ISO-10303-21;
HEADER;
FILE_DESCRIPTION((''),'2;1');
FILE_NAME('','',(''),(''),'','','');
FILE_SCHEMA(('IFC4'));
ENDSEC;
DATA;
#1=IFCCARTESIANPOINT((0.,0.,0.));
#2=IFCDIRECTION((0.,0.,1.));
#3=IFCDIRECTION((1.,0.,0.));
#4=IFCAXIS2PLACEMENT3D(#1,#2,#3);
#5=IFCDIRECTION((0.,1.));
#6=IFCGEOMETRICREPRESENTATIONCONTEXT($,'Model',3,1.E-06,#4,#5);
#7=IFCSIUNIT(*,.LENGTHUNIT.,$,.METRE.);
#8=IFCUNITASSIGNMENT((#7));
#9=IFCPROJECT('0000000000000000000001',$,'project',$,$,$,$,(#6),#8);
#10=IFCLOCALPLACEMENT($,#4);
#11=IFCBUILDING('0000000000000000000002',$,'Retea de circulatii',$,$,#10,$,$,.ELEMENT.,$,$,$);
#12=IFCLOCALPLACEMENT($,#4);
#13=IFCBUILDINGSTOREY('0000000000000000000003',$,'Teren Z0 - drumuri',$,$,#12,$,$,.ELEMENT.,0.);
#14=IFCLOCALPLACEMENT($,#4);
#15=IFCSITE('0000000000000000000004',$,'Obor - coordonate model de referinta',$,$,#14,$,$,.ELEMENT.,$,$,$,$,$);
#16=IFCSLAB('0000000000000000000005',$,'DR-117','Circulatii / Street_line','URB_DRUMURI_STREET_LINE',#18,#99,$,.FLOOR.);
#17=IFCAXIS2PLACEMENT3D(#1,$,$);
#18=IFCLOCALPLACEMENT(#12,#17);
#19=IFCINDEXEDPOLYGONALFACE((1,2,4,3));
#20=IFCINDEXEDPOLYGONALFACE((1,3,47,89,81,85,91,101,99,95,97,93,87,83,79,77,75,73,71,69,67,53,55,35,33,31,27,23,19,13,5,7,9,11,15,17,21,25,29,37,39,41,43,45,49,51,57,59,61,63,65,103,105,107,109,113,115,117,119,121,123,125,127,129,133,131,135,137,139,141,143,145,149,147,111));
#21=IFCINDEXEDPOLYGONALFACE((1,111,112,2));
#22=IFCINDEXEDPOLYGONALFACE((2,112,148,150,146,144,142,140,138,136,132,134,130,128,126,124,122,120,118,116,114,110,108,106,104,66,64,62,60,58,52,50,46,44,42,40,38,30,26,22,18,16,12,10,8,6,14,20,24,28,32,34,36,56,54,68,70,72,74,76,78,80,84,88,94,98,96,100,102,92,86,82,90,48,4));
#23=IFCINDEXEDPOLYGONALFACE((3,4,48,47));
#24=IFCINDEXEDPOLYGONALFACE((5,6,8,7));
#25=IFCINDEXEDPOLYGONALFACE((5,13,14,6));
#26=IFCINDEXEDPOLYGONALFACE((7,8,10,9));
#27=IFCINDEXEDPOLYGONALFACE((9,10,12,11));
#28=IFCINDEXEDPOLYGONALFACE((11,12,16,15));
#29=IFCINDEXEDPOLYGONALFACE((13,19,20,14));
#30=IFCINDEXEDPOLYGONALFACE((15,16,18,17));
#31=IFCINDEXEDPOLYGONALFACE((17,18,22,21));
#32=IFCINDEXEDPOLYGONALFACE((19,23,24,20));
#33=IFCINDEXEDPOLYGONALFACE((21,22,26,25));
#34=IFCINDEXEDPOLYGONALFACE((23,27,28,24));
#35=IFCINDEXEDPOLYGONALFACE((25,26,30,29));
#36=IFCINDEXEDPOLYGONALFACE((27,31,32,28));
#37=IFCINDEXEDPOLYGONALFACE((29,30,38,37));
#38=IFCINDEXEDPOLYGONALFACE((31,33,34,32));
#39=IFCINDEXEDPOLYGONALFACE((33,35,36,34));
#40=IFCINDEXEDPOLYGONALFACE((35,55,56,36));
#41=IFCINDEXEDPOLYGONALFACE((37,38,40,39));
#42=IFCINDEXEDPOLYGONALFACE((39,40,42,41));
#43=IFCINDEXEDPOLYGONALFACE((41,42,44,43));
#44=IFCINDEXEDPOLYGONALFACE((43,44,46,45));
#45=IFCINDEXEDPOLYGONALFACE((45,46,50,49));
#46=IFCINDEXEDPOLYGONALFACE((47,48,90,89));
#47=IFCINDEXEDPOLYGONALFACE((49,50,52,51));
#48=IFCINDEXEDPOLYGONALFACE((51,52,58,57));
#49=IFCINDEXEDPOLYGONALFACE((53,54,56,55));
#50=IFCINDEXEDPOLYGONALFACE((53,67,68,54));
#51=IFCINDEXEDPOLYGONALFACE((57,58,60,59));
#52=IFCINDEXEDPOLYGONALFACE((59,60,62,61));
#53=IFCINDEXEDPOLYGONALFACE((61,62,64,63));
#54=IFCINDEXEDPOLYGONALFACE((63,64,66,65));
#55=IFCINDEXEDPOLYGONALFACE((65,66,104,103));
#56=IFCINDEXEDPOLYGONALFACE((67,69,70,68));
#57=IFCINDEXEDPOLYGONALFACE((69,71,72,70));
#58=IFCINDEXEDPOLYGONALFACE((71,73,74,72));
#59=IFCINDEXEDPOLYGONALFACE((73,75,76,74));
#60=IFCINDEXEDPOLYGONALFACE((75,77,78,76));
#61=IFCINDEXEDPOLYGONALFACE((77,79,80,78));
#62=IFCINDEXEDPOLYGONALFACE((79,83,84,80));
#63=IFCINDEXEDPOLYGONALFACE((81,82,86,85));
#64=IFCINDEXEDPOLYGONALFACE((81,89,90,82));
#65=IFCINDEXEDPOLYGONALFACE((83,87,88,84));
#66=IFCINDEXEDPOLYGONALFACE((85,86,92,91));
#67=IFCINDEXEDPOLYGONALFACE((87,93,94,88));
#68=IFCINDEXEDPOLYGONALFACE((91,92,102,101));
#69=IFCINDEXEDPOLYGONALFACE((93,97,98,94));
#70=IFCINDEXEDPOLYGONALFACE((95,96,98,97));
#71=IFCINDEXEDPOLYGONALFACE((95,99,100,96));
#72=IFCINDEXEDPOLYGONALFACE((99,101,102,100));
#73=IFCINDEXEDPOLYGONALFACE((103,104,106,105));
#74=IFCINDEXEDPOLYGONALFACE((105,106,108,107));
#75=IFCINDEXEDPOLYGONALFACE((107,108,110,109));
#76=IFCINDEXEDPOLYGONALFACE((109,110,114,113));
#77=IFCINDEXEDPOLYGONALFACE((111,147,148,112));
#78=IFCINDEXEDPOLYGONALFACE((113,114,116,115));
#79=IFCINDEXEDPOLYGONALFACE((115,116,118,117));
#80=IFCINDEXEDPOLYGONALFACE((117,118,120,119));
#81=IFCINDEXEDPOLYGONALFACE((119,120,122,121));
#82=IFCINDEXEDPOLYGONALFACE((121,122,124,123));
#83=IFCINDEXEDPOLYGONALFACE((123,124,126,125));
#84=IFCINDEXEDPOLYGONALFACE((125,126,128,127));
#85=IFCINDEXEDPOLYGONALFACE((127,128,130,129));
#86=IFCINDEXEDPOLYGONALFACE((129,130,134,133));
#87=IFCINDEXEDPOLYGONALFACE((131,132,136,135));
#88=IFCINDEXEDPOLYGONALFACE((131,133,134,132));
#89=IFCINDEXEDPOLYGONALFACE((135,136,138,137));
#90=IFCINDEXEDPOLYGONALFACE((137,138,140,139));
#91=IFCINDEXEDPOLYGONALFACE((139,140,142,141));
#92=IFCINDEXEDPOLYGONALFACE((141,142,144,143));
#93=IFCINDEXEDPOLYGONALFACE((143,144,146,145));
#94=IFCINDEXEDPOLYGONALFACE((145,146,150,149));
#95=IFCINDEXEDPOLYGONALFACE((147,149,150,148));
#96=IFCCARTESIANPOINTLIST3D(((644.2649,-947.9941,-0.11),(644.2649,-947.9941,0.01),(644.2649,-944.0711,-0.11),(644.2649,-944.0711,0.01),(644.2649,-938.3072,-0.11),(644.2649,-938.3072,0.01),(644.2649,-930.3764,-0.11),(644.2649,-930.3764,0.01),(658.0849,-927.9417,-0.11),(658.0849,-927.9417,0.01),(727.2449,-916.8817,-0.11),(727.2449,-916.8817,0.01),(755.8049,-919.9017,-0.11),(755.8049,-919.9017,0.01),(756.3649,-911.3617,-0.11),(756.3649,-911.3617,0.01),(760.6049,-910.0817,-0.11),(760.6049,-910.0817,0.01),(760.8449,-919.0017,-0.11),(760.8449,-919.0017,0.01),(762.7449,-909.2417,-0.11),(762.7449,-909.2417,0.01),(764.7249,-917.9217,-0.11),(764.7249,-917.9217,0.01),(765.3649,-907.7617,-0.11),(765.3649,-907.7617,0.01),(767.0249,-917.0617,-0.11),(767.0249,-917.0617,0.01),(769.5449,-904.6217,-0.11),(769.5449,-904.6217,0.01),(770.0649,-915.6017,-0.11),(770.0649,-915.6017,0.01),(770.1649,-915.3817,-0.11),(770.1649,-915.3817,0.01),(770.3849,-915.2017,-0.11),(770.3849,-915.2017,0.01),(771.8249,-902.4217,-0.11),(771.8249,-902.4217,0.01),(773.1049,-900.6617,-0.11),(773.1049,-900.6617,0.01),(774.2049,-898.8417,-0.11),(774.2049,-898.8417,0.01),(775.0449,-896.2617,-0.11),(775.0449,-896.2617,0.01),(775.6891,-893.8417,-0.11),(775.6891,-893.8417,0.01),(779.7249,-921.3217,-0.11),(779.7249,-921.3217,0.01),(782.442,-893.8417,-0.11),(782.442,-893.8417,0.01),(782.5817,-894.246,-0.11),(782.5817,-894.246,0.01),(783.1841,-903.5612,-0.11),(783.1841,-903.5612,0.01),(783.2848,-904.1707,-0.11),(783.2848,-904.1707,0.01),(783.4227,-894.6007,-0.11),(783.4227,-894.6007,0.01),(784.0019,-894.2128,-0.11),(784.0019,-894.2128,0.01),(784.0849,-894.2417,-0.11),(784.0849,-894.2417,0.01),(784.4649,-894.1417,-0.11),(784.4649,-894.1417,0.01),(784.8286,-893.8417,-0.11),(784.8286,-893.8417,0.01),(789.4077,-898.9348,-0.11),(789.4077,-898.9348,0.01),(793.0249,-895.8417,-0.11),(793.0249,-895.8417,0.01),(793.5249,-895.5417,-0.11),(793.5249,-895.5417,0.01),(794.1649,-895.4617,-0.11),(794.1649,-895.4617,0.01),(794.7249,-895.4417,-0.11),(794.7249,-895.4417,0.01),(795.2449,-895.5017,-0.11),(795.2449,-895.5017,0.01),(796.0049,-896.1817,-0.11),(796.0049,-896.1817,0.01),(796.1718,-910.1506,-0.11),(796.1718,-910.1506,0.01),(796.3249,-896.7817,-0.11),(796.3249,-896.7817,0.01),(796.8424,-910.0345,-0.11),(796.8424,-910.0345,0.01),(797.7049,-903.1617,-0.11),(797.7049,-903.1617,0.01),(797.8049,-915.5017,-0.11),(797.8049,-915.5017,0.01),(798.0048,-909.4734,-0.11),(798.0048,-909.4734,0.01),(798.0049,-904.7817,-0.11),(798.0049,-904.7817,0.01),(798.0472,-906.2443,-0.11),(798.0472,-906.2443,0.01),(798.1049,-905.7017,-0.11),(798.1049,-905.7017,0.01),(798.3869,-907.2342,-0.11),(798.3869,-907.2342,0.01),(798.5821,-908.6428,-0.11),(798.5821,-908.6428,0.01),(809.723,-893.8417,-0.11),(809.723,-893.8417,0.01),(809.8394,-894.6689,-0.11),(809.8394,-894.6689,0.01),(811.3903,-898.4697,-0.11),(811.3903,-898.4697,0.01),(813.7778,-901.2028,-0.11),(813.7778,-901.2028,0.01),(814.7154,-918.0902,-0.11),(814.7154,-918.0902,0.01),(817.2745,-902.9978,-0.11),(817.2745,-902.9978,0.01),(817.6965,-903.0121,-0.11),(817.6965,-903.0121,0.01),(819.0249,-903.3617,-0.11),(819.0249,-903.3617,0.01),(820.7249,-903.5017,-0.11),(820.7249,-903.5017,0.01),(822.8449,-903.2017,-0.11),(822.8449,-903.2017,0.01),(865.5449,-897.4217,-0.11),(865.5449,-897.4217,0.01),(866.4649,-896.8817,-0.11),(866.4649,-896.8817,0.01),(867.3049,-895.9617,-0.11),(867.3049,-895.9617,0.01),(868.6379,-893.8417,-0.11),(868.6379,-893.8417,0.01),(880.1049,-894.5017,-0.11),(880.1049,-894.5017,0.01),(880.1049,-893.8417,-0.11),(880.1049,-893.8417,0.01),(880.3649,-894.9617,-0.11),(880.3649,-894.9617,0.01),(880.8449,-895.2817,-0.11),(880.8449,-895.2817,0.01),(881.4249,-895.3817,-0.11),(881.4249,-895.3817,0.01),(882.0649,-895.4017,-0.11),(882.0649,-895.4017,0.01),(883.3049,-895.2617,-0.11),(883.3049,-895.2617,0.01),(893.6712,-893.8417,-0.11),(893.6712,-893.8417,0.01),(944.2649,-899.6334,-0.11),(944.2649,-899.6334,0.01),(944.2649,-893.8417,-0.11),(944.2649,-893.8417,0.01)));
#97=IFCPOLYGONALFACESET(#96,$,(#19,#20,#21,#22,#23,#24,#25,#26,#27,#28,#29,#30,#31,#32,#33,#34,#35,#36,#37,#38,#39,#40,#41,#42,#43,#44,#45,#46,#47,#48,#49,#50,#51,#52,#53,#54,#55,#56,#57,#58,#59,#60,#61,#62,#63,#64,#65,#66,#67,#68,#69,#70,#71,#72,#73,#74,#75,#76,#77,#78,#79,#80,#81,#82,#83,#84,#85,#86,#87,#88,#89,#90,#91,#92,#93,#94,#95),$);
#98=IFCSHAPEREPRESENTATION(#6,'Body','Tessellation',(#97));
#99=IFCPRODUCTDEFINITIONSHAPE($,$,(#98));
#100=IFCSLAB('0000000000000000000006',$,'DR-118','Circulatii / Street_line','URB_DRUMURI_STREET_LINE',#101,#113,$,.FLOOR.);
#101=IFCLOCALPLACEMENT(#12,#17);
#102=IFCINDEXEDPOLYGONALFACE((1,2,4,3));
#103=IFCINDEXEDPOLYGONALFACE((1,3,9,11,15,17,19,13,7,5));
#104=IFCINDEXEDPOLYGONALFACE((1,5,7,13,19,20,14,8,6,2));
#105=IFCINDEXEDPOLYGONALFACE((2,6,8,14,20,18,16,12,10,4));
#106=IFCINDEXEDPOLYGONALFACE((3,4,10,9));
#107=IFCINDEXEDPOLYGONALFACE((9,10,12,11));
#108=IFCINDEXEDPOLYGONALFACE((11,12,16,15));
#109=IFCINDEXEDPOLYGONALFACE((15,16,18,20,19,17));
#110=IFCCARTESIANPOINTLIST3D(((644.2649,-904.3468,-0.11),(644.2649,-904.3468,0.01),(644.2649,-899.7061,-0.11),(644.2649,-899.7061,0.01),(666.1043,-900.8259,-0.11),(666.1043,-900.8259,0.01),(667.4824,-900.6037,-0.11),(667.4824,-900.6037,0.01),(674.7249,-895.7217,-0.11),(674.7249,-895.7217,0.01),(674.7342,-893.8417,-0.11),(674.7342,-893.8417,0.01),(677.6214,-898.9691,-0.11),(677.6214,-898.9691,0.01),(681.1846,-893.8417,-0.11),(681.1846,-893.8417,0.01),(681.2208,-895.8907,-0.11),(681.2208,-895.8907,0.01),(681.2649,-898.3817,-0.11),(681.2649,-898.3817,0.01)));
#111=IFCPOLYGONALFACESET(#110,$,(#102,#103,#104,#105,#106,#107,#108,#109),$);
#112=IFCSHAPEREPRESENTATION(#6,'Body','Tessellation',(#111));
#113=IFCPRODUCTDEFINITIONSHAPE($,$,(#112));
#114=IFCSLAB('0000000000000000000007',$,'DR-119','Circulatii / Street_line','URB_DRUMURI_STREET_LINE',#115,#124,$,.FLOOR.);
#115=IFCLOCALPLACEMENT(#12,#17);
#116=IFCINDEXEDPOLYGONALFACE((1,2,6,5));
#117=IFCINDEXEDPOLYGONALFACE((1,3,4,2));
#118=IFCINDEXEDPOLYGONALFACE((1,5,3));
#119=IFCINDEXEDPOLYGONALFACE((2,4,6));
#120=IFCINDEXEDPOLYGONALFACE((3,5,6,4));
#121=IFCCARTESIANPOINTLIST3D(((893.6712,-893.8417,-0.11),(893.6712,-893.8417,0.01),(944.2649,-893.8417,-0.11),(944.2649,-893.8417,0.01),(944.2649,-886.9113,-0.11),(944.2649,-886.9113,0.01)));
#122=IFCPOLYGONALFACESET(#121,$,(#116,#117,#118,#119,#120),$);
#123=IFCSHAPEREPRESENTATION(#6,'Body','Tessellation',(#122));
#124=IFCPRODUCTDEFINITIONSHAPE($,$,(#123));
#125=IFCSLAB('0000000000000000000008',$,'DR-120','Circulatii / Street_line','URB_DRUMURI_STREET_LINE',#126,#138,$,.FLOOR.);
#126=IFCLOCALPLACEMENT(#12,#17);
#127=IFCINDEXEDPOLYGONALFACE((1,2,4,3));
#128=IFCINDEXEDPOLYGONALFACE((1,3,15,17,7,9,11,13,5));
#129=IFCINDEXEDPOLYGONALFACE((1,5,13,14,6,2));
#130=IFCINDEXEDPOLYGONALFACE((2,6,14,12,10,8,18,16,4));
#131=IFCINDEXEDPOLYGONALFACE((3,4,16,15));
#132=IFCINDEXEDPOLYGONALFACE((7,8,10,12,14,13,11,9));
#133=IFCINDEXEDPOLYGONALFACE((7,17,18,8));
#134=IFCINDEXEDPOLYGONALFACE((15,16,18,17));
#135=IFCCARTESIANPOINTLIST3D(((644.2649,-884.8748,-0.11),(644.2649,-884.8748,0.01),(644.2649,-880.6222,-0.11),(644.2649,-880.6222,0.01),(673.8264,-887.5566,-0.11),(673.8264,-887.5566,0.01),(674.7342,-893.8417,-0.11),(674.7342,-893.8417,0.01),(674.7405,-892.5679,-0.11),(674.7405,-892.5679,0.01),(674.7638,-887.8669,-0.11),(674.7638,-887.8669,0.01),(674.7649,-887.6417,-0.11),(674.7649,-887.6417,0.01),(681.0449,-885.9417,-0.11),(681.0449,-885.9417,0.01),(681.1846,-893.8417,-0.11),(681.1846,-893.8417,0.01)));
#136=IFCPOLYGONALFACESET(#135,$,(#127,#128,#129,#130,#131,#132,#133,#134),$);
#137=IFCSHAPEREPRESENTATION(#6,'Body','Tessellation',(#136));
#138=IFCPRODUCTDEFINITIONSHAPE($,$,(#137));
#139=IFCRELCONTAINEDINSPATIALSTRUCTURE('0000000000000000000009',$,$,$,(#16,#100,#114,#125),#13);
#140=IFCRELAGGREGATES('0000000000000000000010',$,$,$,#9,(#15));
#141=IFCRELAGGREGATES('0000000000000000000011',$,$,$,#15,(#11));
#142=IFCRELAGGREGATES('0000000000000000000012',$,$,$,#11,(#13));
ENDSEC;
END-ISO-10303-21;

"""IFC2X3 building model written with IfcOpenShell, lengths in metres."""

from ifc_helpers import new_model, si_unit, direction, frame, origin_with_axes, place, context, project, spatial, polyline, outline, extrude, element, save


model = new_model("IFC2X3")

# Units and contexts
model_context = context("Model", 3, precision=1e-06, world=origin_with_axes(), true_north=direction((0.0, 1.0)))
ifc_project = project(units=[si_unit("LENGTHUNIT", "METRE")], contexts=[model_context])

# Site, building, storey
site_placement = place(None, origin_with_axes())
site = spatial("IfcSite", under=ifc_project, at=site_placement, Name="Obor - coordonate model de referinta", CompositionType="ELEMENT")
building_placement = place(None, origin_with_axes())
building = spatial("IfcBuilding", under=site, at=building_placement, Name="Retea de circulatii", CompositionType="ELEMENT")
storey_placement = place(None, origin_with_axes())
storey = spatial("IfcBuildingStorey", under=building, at=storey_placement, Name="Teren Z0 - drumuri", CompositionType="ELEMENT", Elevation=0.0)

# Slabs
slab_1_placement = place(None, origin_with_axes())
element("IfcSlab", 1, at=slab_1_placement, inside=storey, Name="DR-117", Description="Circulatii / Street_line", ObjectType="URB_DRUMURI_STREET_LINE", PredefinedType="FLOOR", context=model_context, shape_type="SweptSolid", body=[
    extrude(outline(polyline([(644.2649, -947.9941), (814.7154, -918.0902), (944.2649, -899.6334), (944.2649, -893.8417), (893.6712, -893.8417), (883.3049, -895.2617), (882.0649, -895.4017), (881.4249, -895.3817), (880.8449, -895.2817), (880.3649, -894.9617), (880.1049, -894.5017), (880.1049, -893.8417), (868.6379, -893.8417), (867.3049, -895.9617), (866.4649, -896.8817), (865.5449, -897.4217), (822.8449, -903.2017), (820.7249, -903.5017), (819.0249, -903.3617), (817.6965, -903.0121), (817.2745, -902.9978), (813.7778, -901.2028), (811.3903, -898.4697), (809.8394, -894.6689), (809.723, -893.8417), (784.8286, -893.8417), (784.4649, -894.1417), (784.0849, -894.2417), (784.0019, -894.2128), (783.4227, -894.6007), (782.5817, -894.246), (782.442, -893.8417), (775.6891, -893.8417), (775.0449, -896.2617), (774.2049, -898.8417), (773.1049, -900.6617), (771.8249, -902.4217), (769.5449, -904.6217), (765.3649, -907.7617), (762.7449, -909.2417), (760.6049, -910.0817), (756.3649, -911.3617), (727.2449, -916.8817), (658.0849, -927.9417), (644.2649, -930.3764), (644.2649, -938.3072), (755.8049, -919.9017), (760.8449, -919.0017), (764.7249, -917.9217), (767.0249, -917.0617), (770.0649, -915.6017), (770.1649, -915.3817), (770.3849, -915.2017), (783.2848, -904.1707), (783.1841, -903.5612), (789.4077, -898.9348), (793.0249, -895.8417), (793.5249, -895.5417), (794.1649, -895.4617), (794.7249, -895.4417), (795.2449, -895.5017), (796.0049, -896.1817), (796.3249, -896.7817), (797.7049, -903.1617), (798.0049, -904.7817), (798.1049, -905.7017), (798.0472, -906.2443), (798.3869, -907.2342), (798.5821, -908.6428), (798.0048, -909.4734), (796.8424, -910.0345), (796.1718, -910.1506), (797.8049, -915.5017), (779.7249, -921.3217), (644.2649, -944.0711), (644.2649, -947.9941)])), frame((0.0, 0.0, -0.11), z_axis=(0.0, 0.0, 1.0), x_axis=(1.0, 0.0, 0.0)), (0.0, 0.0, 1.0), 0.12),
])
slab_2_placement = place(None, origin_with_axes())
element("IfcSlab", 2, at=slab_2_placement, inside=storey, Name="DR-118", Description="Circulatii / Street_line", ObjectType="URB_DRUMURI_STREET_LINE", PredefinedType="FLOOR", context=model_context, shape_type="SweptSolid", body=[
    extrude(outline(polyline([(681.2649, -898.3817), (681.2208, -895.8907), (681.1846, -893.8417), (674.7342, -893.8417), (674.7249, -895.7217), (644.2649, -899.7061), (644.2649, -904.3468), (666.1043, -900.8259), (667.4824, -900.6037), (677.6214, -898.9691), (681.2649, -898.3817)])), frame((0.0, 0.0, -0.11), z_axis=(0.0, 0.0, 1.0), x_axis=(1.0, 0.0, 0.0)), (0.0, 0.0, 1.0), 0.12),
])
slab_3_placement = place(None, origin_with_axes())
element("IfcSlab", 3, at=slab_3_placement, inside=storey, Name="DR-119", Description="Circulatii / Street_line", ObjectType="URB_DRUMURI_STREET_LINE", PredefinedType="FLOOR", context=model_context, shape_type="SweptSolid", body=[
    extrude(outline(polyline([(893.6712, -893.8417), (944.2649, -893.8417), (944.2649, -886.9113), (893.6712, -893.8417)])), frame((0.0, 0.0, -0.11), z_axis=(0.0, 0.0, 1.0), x_axis=(1.0, 0.0, 0.0)), (0.0, 0.0, 1.0), 0.12),
])
slab_4_placement = place(None, origin_with_axes())
element("IfcSlab", 4, at=slab_4_placement, inside=storey, Name="DR-120", Description="Circulatii / Street_line", ObjectType="URB_DRUMURI_STREET_LINE", PredefinedType="FLOOR", context=model_context, shape_type="SweptSolid", body=[
    extrude(outline(polyline([(674.7405, -892.5679), (674.7342, -893.8417), (681.1846, -893.8417), (681.0449, -885.9417), (644.2649, -880.6222), (644.2649, -884.8748), (673.8264, -887.5566), (674.7649, -887.6417), (674.7638, -887.8669), (674.7405, -892.5679)])), frame((0.0, 0.0, -0.11), z_axis=(0.0, 0.0, 1.0), x_axis=(1.0, 0.0, 0.0)), (0.0, 0.0, 1.0), 0.12),
])

save(model, "model.ifc")
